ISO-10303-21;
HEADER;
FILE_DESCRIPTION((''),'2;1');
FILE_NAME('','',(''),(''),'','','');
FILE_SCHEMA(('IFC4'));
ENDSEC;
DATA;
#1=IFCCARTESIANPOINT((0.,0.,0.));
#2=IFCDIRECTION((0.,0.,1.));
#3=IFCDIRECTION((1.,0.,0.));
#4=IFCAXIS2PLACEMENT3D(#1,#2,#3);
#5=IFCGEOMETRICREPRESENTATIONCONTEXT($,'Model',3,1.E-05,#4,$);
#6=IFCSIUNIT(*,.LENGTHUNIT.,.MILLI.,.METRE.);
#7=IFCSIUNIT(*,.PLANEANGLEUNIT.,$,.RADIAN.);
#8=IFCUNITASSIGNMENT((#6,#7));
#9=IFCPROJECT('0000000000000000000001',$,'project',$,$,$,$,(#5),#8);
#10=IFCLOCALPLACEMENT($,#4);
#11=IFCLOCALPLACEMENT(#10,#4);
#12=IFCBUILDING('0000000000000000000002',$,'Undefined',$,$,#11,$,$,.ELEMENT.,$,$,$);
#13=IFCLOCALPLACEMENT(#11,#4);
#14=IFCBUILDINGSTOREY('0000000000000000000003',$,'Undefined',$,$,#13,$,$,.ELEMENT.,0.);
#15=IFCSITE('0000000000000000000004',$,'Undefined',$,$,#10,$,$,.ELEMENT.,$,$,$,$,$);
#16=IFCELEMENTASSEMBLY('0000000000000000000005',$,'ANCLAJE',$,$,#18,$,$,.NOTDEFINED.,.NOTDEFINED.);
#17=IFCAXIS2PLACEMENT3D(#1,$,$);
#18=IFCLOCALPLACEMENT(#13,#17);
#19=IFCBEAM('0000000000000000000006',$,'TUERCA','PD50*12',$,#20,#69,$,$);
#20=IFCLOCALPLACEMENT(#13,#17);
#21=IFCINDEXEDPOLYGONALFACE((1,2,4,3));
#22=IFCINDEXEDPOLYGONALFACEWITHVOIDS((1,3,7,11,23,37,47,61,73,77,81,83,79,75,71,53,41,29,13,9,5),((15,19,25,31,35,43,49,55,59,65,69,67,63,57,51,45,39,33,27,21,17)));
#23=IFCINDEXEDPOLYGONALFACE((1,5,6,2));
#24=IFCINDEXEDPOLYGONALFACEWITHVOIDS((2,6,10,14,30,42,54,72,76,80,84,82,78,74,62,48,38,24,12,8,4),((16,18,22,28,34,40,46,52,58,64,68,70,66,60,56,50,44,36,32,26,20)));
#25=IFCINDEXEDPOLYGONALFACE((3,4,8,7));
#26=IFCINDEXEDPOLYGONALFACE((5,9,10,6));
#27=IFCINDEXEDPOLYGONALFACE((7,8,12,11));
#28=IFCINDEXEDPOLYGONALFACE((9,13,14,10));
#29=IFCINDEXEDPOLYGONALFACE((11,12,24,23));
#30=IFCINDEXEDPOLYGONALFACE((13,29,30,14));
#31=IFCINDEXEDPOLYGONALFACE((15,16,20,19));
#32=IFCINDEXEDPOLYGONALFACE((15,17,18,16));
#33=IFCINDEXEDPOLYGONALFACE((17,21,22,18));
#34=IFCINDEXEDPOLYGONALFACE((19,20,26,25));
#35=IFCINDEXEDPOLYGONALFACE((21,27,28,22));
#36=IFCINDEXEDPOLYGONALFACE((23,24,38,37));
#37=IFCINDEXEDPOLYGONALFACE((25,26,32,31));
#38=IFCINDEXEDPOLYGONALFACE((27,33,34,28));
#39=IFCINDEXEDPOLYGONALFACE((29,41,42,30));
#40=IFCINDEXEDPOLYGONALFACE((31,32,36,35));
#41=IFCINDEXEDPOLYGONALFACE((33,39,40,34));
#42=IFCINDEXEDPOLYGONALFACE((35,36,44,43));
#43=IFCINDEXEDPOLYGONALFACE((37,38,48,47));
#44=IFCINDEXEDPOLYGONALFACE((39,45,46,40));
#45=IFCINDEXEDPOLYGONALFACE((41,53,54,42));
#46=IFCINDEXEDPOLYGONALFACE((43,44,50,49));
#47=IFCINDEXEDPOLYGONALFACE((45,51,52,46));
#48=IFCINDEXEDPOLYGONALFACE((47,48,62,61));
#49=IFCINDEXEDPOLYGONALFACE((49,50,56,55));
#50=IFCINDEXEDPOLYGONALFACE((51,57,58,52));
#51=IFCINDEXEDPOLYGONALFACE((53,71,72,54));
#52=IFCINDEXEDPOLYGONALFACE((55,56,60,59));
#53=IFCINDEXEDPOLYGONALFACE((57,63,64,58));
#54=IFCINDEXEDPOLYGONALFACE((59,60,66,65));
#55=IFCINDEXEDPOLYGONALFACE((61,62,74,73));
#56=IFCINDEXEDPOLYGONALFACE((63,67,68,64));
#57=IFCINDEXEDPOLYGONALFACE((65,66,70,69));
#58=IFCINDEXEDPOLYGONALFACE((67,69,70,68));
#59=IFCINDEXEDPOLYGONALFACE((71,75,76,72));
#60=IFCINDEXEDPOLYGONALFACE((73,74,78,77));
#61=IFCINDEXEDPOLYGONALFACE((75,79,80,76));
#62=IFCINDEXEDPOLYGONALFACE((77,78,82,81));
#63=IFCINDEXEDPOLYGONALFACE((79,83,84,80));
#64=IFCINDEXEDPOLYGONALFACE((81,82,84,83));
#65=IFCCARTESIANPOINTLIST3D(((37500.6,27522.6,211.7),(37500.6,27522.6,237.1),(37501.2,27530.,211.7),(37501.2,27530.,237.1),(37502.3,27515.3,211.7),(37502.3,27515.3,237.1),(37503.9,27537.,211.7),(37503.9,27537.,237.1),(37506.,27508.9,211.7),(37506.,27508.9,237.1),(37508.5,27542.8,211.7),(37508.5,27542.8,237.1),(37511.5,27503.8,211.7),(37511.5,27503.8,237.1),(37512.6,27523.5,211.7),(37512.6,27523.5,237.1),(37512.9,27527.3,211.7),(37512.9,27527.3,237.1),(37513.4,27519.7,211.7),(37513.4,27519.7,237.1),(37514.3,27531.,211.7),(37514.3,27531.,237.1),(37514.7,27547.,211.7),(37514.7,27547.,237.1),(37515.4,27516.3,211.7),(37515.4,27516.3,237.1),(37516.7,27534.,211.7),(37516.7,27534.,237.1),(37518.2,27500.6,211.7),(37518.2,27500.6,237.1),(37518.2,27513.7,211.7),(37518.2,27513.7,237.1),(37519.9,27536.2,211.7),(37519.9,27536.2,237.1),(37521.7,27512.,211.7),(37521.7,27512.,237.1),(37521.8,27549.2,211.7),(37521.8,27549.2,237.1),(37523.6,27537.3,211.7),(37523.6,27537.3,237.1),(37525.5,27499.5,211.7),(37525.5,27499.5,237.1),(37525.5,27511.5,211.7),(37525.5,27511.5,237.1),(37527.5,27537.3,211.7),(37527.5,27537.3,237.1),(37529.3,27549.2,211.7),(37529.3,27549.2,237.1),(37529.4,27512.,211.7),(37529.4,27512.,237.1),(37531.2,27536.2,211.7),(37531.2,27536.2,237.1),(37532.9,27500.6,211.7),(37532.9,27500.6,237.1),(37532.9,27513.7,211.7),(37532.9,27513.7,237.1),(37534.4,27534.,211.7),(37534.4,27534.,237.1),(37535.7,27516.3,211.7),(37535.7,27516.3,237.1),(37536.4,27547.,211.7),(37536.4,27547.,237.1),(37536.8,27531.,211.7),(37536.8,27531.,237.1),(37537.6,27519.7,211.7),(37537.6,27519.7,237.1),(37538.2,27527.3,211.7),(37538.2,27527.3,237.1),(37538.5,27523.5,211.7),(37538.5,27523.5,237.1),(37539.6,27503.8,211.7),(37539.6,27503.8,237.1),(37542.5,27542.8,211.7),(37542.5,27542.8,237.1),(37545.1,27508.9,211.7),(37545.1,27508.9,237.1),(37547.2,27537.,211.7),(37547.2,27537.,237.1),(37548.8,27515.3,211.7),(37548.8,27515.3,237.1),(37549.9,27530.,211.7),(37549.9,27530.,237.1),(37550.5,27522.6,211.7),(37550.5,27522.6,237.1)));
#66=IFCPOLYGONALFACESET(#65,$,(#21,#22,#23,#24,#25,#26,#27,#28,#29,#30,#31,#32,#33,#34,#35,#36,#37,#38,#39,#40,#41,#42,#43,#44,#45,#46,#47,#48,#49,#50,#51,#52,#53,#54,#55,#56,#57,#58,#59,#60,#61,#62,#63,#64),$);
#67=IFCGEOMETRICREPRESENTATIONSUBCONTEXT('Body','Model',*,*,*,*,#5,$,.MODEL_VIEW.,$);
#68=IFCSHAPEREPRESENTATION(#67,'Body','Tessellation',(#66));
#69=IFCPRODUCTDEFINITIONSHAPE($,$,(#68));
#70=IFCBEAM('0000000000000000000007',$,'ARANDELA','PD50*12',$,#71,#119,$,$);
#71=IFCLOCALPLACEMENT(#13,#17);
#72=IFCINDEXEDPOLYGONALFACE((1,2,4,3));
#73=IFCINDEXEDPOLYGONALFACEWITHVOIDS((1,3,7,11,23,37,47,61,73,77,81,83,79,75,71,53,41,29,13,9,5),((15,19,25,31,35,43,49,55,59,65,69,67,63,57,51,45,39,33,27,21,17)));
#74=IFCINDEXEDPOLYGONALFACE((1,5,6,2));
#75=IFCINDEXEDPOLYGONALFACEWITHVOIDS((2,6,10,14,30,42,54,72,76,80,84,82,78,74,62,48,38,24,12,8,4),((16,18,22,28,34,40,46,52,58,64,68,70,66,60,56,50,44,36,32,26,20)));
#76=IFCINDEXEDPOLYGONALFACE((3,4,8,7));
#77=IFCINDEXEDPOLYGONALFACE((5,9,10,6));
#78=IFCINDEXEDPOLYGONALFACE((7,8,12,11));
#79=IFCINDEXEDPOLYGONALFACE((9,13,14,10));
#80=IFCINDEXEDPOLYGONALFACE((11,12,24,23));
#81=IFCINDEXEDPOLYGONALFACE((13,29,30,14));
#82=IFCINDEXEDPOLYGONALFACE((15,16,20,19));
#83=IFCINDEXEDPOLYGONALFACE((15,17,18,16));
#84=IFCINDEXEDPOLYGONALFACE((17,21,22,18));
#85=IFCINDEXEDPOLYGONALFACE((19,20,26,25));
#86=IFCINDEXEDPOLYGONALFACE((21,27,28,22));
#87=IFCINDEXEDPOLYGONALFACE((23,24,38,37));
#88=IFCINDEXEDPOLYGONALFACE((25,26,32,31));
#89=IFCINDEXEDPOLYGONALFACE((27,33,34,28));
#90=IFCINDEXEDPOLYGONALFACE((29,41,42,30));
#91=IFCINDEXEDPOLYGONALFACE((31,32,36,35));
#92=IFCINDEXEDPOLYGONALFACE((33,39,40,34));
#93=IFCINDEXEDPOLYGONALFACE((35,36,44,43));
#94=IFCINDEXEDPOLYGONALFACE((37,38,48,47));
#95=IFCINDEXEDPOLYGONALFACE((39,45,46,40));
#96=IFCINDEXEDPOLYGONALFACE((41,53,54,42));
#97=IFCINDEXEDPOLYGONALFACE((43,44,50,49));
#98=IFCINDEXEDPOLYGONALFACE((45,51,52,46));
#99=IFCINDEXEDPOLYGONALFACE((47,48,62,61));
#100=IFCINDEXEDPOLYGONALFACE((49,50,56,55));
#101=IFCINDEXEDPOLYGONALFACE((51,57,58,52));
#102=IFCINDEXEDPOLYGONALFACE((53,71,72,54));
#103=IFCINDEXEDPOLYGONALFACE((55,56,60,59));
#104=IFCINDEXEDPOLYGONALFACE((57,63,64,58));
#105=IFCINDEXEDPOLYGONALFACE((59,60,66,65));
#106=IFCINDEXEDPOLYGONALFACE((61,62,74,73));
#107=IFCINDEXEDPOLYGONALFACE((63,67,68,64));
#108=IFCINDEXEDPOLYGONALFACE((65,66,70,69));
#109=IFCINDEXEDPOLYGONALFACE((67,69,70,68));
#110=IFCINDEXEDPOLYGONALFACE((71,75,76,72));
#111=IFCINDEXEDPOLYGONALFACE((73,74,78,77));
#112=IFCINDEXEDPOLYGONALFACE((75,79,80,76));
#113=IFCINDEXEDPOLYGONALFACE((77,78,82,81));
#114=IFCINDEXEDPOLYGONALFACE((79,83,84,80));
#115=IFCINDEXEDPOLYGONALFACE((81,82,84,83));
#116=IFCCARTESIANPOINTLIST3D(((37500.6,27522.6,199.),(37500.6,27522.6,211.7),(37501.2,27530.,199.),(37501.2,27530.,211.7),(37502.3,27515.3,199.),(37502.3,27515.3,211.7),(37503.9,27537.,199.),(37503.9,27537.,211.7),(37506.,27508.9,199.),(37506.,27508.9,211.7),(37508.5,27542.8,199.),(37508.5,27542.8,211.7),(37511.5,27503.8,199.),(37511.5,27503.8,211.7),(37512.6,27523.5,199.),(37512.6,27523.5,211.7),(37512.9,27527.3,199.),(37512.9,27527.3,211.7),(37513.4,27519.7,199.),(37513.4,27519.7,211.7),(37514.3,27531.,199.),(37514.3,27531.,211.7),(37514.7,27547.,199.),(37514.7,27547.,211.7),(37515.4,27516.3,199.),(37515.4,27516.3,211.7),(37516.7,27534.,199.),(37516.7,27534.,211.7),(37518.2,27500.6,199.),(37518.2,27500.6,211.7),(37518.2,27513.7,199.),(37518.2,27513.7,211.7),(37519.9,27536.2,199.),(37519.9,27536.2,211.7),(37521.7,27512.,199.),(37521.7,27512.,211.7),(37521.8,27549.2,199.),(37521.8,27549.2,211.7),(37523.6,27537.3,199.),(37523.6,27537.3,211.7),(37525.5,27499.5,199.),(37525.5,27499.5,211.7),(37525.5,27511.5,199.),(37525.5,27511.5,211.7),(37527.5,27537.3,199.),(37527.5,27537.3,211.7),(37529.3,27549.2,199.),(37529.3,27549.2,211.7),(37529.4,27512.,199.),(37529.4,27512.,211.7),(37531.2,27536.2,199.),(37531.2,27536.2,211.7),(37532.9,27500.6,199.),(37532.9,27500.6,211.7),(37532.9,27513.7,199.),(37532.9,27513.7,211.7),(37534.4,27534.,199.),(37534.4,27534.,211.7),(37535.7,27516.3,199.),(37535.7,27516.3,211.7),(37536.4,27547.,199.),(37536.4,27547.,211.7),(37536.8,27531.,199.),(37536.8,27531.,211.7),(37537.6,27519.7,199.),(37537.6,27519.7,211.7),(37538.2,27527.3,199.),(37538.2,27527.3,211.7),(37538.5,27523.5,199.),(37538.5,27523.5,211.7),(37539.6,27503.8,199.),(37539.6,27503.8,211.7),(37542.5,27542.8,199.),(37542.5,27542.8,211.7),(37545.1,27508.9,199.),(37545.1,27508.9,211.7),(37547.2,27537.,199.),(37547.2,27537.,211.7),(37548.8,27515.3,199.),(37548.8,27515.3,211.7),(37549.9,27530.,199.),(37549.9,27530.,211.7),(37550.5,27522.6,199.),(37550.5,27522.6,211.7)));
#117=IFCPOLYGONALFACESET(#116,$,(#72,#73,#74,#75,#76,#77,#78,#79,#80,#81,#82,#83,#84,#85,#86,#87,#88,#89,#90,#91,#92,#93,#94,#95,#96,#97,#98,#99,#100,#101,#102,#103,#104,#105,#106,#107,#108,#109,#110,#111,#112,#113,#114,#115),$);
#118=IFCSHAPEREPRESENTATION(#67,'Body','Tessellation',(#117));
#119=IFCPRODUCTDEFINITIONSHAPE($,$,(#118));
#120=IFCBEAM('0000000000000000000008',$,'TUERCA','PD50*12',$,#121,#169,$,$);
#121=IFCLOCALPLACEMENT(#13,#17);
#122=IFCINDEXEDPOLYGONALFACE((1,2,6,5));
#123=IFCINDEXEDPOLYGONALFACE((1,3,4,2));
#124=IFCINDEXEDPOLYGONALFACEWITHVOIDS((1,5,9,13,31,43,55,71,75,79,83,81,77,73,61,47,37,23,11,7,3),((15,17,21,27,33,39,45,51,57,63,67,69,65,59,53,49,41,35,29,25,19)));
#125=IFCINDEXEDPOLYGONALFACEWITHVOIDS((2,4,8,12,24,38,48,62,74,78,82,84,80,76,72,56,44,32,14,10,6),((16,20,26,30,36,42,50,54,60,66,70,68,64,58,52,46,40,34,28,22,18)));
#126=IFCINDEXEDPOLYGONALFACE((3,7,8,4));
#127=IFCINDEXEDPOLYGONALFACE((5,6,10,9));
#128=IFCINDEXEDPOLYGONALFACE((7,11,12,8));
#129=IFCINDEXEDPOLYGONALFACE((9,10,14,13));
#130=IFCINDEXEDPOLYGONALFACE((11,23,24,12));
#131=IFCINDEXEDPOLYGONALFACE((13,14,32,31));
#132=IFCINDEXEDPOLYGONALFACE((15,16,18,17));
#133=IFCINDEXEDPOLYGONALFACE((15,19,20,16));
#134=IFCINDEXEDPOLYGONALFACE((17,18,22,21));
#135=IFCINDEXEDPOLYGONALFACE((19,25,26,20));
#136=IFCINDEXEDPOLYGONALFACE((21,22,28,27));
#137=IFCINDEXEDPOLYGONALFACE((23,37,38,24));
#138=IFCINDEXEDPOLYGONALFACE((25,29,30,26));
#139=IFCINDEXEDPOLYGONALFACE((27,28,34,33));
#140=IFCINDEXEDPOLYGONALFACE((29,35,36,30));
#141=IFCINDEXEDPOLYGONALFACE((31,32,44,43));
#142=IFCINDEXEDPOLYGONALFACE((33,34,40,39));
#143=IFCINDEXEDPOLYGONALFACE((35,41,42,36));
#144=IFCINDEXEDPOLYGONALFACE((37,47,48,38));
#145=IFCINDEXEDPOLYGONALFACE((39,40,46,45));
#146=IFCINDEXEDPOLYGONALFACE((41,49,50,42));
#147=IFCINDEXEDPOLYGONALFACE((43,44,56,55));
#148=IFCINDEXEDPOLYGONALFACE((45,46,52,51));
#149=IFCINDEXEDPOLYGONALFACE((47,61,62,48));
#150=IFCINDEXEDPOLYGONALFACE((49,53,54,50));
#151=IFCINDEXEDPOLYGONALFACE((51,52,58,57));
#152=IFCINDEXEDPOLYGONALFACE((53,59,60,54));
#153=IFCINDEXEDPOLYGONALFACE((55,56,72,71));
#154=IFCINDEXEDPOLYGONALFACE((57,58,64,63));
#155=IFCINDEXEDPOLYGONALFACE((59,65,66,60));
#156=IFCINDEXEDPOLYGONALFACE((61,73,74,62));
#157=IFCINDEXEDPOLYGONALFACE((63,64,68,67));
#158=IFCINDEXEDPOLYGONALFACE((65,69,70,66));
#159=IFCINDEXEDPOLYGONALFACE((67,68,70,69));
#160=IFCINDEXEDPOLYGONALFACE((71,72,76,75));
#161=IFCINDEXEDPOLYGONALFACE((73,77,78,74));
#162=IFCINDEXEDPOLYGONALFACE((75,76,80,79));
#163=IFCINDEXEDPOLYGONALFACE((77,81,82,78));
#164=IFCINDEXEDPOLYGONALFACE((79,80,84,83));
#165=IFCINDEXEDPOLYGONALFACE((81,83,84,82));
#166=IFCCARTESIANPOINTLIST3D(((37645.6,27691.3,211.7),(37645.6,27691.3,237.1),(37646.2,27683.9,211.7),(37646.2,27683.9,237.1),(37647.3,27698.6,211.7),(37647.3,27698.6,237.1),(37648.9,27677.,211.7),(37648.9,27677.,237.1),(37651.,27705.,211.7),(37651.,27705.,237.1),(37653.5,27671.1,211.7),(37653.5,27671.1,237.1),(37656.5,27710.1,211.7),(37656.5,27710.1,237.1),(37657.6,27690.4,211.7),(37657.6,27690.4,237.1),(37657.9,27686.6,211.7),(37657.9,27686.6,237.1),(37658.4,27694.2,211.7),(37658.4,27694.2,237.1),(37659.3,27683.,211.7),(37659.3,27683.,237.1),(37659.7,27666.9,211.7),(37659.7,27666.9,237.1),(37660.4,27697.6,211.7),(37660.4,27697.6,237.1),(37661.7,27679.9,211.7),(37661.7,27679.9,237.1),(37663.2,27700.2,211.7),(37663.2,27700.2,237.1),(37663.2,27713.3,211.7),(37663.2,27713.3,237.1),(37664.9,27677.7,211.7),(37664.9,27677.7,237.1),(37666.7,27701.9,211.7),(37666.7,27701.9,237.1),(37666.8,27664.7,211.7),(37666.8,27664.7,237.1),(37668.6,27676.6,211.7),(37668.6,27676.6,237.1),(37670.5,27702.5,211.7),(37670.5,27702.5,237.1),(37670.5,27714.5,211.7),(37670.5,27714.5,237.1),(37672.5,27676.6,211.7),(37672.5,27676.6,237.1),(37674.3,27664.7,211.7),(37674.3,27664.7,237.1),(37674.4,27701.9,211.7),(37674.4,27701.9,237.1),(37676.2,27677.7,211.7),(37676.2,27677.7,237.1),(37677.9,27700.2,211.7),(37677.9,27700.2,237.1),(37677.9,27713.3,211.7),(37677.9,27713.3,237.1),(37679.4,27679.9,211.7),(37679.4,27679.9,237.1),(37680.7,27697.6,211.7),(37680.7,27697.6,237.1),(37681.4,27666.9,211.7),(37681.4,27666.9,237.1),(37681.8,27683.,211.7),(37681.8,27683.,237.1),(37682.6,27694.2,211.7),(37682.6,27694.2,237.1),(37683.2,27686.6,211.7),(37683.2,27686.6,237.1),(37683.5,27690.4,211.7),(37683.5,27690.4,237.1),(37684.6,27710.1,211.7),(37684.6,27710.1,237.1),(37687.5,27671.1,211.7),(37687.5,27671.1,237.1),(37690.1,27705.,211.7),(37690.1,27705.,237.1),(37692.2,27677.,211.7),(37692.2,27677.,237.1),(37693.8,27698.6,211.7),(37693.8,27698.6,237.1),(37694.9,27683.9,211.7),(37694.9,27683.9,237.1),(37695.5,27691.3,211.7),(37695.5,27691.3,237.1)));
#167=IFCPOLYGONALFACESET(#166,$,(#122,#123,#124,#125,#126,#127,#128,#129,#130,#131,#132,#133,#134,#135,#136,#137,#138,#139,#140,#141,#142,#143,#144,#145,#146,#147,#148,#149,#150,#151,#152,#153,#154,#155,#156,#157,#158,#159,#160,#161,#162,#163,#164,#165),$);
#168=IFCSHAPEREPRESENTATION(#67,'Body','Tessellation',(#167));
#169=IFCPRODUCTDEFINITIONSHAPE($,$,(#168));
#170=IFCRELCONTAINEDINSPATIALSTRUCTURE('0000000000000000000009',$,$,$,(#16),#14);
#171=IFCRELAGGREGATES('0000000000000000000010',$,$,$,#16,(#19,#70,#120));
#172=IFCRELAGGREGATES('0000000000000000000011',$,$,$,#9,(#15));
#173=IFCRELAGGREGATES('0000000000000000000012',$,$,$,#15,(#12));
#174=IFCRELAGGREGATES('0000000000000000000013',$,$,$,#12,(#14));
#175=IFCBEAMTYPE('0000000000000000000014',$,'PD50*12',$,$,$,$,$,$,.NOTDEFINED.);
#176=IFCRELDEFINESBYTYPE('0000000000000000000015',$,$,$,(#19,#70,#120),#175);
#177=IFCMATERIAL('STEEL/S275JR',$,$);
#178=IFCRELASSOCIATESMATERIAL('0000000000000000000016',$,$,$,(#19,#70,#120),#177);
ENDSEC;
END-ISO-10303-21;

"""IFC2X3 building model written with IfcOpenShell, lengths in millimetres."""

from ifc_helpers import new_model, si_unit, frame, origin_with_axes, origin_2d_with_axis, place, context, subcontext, project, spatial, hollow_circle, extrude, material, type_object, element, aggregate, save


model = new_model("IFC2X3")

# Units and contexts
model_context = context("Model", 3, precision=1e-05, world=origin_with_axes())
body_context = subcontext(model_context, "Body", "Model", "MODEL_VIEW")
ifc_project = project(units=[si_unit("LENGTHUNIT", "METRE", prefix="MILLI"), si_unit("PLANEANGLEUNIT", "RADIAN")], contexts=[model_context])

# Site, building, storey
site_placement = place(None, origin_with_axes())
site = spatial("IfcSite", under=ifc_project, at=site_placement, Name="Undefined", CompositionType="ELEMENT")
building_placement = place(site_placement, origin_with_axes())
building = spatial("IfcBuilding", under=site, at=building_placement, Name="Undefined", CompositionType="ELEMENT")
storey_placement = place(building_placement, origin_with_axes())
storey = spatial("IfcBuildingStorey", under=building, at=storey_placement, Name="Undefined", CompositionType="ELEMENT", Elevation=0.0)

# Element assembly, beams
assembly_1_placement = place(storey_placement, origin_with_axes())
assembly_1 = element("IfcElementAssembly", 1, at=assembly_1_placement, inside=storey, Name="ANCLAJE", AssemblyPlace="NOTDEFINED", PredefinedType="NOTDEFINED")
ifc_material_1 = material(Name="STEEL/S275JR")
beam_type_1 = type_object("IfcBeamType", Name="PD50*12", PredefinedType="NOTDEFINED")
beam_1_placement = place(assembly_1_placement, frame((37525.5, 27524.5, 237.1), z_axis=(1.0, 0.0, 0.0), x_axis=(0.0, 0.0, -1.0)))
beam_1 = element("IfcBeam", 2, at=beam_1_placement, type_object=beam_type_1, material=ifc_material_1, Name="TUERCA", Description="PD50*12", context=body_context, shape_type="SweptSolid", body=[
    extrude(hollow_circle(Radius=25.0, WallThickness=12.0, at=origin_2d_with_axis()), frame((25.4, 0.0, 0.0), z_axis=(-1.0, 0.0, 0.0), x_axis=(0.0, -1.0, 0.0)), (0.0, 0.0, 1.0), 25.4),
])
beam_2_placement = place(assembly_1_placement, frame((37525.5, 27524.5, 211.7), z_axis=(1.0, 0.0, 0.0), x_axis=(0.0, 0.0, -1.0)))
beam_2 = element("IfcBeam", 3, at=beam_2_placement, type_object=beam_type_1, material=ifc_material_1, Name="ARANDELA", Description="PD50*12", context=body_context, shape_type="SweptSolid", body=[
    extrude(hollow_circle(Radius=25.0, WallThickness=12.0, at=origin_2d_with_axis()), frame((12.7, 0.0, 0.0), z_axis=(-1.0, 0.0, 0.0), x_axis=(0.0, -1.0, 0.0)), (0.0, 0.0, 1.0), 12.7),
])
beam_3_placement = place(assembly_1_placement, frame((37670.5, 27689.5, 237.1), z_axis=(-1.0, 0.0, 0.0), x_axis=(0.0, 0.0, -1.0)))
beam_3 = element("IfcBeam", 4, at=beam_3_placement, type_object=beam_type_1, material=ifc_material_1, Name="TUERCA", Description="PD50*12", context=body_context, shape_type="SweptSolid", body=[
    extrude(hollow_circle(Radius=25.0, WallThickness=12.0, at=origin_2d_with_axis()), frame((25.4, 0.0, 0.0), z_axis=(-1.0, 0.0, 0.0), x_axis=(0.0, -1.0, 0.0)), (0.0, 0.0, 1.0), 25.4),
])

aggregate(assembly_1, [beam_1, beam_2, beam_3])

save(model, "model.ifc")
